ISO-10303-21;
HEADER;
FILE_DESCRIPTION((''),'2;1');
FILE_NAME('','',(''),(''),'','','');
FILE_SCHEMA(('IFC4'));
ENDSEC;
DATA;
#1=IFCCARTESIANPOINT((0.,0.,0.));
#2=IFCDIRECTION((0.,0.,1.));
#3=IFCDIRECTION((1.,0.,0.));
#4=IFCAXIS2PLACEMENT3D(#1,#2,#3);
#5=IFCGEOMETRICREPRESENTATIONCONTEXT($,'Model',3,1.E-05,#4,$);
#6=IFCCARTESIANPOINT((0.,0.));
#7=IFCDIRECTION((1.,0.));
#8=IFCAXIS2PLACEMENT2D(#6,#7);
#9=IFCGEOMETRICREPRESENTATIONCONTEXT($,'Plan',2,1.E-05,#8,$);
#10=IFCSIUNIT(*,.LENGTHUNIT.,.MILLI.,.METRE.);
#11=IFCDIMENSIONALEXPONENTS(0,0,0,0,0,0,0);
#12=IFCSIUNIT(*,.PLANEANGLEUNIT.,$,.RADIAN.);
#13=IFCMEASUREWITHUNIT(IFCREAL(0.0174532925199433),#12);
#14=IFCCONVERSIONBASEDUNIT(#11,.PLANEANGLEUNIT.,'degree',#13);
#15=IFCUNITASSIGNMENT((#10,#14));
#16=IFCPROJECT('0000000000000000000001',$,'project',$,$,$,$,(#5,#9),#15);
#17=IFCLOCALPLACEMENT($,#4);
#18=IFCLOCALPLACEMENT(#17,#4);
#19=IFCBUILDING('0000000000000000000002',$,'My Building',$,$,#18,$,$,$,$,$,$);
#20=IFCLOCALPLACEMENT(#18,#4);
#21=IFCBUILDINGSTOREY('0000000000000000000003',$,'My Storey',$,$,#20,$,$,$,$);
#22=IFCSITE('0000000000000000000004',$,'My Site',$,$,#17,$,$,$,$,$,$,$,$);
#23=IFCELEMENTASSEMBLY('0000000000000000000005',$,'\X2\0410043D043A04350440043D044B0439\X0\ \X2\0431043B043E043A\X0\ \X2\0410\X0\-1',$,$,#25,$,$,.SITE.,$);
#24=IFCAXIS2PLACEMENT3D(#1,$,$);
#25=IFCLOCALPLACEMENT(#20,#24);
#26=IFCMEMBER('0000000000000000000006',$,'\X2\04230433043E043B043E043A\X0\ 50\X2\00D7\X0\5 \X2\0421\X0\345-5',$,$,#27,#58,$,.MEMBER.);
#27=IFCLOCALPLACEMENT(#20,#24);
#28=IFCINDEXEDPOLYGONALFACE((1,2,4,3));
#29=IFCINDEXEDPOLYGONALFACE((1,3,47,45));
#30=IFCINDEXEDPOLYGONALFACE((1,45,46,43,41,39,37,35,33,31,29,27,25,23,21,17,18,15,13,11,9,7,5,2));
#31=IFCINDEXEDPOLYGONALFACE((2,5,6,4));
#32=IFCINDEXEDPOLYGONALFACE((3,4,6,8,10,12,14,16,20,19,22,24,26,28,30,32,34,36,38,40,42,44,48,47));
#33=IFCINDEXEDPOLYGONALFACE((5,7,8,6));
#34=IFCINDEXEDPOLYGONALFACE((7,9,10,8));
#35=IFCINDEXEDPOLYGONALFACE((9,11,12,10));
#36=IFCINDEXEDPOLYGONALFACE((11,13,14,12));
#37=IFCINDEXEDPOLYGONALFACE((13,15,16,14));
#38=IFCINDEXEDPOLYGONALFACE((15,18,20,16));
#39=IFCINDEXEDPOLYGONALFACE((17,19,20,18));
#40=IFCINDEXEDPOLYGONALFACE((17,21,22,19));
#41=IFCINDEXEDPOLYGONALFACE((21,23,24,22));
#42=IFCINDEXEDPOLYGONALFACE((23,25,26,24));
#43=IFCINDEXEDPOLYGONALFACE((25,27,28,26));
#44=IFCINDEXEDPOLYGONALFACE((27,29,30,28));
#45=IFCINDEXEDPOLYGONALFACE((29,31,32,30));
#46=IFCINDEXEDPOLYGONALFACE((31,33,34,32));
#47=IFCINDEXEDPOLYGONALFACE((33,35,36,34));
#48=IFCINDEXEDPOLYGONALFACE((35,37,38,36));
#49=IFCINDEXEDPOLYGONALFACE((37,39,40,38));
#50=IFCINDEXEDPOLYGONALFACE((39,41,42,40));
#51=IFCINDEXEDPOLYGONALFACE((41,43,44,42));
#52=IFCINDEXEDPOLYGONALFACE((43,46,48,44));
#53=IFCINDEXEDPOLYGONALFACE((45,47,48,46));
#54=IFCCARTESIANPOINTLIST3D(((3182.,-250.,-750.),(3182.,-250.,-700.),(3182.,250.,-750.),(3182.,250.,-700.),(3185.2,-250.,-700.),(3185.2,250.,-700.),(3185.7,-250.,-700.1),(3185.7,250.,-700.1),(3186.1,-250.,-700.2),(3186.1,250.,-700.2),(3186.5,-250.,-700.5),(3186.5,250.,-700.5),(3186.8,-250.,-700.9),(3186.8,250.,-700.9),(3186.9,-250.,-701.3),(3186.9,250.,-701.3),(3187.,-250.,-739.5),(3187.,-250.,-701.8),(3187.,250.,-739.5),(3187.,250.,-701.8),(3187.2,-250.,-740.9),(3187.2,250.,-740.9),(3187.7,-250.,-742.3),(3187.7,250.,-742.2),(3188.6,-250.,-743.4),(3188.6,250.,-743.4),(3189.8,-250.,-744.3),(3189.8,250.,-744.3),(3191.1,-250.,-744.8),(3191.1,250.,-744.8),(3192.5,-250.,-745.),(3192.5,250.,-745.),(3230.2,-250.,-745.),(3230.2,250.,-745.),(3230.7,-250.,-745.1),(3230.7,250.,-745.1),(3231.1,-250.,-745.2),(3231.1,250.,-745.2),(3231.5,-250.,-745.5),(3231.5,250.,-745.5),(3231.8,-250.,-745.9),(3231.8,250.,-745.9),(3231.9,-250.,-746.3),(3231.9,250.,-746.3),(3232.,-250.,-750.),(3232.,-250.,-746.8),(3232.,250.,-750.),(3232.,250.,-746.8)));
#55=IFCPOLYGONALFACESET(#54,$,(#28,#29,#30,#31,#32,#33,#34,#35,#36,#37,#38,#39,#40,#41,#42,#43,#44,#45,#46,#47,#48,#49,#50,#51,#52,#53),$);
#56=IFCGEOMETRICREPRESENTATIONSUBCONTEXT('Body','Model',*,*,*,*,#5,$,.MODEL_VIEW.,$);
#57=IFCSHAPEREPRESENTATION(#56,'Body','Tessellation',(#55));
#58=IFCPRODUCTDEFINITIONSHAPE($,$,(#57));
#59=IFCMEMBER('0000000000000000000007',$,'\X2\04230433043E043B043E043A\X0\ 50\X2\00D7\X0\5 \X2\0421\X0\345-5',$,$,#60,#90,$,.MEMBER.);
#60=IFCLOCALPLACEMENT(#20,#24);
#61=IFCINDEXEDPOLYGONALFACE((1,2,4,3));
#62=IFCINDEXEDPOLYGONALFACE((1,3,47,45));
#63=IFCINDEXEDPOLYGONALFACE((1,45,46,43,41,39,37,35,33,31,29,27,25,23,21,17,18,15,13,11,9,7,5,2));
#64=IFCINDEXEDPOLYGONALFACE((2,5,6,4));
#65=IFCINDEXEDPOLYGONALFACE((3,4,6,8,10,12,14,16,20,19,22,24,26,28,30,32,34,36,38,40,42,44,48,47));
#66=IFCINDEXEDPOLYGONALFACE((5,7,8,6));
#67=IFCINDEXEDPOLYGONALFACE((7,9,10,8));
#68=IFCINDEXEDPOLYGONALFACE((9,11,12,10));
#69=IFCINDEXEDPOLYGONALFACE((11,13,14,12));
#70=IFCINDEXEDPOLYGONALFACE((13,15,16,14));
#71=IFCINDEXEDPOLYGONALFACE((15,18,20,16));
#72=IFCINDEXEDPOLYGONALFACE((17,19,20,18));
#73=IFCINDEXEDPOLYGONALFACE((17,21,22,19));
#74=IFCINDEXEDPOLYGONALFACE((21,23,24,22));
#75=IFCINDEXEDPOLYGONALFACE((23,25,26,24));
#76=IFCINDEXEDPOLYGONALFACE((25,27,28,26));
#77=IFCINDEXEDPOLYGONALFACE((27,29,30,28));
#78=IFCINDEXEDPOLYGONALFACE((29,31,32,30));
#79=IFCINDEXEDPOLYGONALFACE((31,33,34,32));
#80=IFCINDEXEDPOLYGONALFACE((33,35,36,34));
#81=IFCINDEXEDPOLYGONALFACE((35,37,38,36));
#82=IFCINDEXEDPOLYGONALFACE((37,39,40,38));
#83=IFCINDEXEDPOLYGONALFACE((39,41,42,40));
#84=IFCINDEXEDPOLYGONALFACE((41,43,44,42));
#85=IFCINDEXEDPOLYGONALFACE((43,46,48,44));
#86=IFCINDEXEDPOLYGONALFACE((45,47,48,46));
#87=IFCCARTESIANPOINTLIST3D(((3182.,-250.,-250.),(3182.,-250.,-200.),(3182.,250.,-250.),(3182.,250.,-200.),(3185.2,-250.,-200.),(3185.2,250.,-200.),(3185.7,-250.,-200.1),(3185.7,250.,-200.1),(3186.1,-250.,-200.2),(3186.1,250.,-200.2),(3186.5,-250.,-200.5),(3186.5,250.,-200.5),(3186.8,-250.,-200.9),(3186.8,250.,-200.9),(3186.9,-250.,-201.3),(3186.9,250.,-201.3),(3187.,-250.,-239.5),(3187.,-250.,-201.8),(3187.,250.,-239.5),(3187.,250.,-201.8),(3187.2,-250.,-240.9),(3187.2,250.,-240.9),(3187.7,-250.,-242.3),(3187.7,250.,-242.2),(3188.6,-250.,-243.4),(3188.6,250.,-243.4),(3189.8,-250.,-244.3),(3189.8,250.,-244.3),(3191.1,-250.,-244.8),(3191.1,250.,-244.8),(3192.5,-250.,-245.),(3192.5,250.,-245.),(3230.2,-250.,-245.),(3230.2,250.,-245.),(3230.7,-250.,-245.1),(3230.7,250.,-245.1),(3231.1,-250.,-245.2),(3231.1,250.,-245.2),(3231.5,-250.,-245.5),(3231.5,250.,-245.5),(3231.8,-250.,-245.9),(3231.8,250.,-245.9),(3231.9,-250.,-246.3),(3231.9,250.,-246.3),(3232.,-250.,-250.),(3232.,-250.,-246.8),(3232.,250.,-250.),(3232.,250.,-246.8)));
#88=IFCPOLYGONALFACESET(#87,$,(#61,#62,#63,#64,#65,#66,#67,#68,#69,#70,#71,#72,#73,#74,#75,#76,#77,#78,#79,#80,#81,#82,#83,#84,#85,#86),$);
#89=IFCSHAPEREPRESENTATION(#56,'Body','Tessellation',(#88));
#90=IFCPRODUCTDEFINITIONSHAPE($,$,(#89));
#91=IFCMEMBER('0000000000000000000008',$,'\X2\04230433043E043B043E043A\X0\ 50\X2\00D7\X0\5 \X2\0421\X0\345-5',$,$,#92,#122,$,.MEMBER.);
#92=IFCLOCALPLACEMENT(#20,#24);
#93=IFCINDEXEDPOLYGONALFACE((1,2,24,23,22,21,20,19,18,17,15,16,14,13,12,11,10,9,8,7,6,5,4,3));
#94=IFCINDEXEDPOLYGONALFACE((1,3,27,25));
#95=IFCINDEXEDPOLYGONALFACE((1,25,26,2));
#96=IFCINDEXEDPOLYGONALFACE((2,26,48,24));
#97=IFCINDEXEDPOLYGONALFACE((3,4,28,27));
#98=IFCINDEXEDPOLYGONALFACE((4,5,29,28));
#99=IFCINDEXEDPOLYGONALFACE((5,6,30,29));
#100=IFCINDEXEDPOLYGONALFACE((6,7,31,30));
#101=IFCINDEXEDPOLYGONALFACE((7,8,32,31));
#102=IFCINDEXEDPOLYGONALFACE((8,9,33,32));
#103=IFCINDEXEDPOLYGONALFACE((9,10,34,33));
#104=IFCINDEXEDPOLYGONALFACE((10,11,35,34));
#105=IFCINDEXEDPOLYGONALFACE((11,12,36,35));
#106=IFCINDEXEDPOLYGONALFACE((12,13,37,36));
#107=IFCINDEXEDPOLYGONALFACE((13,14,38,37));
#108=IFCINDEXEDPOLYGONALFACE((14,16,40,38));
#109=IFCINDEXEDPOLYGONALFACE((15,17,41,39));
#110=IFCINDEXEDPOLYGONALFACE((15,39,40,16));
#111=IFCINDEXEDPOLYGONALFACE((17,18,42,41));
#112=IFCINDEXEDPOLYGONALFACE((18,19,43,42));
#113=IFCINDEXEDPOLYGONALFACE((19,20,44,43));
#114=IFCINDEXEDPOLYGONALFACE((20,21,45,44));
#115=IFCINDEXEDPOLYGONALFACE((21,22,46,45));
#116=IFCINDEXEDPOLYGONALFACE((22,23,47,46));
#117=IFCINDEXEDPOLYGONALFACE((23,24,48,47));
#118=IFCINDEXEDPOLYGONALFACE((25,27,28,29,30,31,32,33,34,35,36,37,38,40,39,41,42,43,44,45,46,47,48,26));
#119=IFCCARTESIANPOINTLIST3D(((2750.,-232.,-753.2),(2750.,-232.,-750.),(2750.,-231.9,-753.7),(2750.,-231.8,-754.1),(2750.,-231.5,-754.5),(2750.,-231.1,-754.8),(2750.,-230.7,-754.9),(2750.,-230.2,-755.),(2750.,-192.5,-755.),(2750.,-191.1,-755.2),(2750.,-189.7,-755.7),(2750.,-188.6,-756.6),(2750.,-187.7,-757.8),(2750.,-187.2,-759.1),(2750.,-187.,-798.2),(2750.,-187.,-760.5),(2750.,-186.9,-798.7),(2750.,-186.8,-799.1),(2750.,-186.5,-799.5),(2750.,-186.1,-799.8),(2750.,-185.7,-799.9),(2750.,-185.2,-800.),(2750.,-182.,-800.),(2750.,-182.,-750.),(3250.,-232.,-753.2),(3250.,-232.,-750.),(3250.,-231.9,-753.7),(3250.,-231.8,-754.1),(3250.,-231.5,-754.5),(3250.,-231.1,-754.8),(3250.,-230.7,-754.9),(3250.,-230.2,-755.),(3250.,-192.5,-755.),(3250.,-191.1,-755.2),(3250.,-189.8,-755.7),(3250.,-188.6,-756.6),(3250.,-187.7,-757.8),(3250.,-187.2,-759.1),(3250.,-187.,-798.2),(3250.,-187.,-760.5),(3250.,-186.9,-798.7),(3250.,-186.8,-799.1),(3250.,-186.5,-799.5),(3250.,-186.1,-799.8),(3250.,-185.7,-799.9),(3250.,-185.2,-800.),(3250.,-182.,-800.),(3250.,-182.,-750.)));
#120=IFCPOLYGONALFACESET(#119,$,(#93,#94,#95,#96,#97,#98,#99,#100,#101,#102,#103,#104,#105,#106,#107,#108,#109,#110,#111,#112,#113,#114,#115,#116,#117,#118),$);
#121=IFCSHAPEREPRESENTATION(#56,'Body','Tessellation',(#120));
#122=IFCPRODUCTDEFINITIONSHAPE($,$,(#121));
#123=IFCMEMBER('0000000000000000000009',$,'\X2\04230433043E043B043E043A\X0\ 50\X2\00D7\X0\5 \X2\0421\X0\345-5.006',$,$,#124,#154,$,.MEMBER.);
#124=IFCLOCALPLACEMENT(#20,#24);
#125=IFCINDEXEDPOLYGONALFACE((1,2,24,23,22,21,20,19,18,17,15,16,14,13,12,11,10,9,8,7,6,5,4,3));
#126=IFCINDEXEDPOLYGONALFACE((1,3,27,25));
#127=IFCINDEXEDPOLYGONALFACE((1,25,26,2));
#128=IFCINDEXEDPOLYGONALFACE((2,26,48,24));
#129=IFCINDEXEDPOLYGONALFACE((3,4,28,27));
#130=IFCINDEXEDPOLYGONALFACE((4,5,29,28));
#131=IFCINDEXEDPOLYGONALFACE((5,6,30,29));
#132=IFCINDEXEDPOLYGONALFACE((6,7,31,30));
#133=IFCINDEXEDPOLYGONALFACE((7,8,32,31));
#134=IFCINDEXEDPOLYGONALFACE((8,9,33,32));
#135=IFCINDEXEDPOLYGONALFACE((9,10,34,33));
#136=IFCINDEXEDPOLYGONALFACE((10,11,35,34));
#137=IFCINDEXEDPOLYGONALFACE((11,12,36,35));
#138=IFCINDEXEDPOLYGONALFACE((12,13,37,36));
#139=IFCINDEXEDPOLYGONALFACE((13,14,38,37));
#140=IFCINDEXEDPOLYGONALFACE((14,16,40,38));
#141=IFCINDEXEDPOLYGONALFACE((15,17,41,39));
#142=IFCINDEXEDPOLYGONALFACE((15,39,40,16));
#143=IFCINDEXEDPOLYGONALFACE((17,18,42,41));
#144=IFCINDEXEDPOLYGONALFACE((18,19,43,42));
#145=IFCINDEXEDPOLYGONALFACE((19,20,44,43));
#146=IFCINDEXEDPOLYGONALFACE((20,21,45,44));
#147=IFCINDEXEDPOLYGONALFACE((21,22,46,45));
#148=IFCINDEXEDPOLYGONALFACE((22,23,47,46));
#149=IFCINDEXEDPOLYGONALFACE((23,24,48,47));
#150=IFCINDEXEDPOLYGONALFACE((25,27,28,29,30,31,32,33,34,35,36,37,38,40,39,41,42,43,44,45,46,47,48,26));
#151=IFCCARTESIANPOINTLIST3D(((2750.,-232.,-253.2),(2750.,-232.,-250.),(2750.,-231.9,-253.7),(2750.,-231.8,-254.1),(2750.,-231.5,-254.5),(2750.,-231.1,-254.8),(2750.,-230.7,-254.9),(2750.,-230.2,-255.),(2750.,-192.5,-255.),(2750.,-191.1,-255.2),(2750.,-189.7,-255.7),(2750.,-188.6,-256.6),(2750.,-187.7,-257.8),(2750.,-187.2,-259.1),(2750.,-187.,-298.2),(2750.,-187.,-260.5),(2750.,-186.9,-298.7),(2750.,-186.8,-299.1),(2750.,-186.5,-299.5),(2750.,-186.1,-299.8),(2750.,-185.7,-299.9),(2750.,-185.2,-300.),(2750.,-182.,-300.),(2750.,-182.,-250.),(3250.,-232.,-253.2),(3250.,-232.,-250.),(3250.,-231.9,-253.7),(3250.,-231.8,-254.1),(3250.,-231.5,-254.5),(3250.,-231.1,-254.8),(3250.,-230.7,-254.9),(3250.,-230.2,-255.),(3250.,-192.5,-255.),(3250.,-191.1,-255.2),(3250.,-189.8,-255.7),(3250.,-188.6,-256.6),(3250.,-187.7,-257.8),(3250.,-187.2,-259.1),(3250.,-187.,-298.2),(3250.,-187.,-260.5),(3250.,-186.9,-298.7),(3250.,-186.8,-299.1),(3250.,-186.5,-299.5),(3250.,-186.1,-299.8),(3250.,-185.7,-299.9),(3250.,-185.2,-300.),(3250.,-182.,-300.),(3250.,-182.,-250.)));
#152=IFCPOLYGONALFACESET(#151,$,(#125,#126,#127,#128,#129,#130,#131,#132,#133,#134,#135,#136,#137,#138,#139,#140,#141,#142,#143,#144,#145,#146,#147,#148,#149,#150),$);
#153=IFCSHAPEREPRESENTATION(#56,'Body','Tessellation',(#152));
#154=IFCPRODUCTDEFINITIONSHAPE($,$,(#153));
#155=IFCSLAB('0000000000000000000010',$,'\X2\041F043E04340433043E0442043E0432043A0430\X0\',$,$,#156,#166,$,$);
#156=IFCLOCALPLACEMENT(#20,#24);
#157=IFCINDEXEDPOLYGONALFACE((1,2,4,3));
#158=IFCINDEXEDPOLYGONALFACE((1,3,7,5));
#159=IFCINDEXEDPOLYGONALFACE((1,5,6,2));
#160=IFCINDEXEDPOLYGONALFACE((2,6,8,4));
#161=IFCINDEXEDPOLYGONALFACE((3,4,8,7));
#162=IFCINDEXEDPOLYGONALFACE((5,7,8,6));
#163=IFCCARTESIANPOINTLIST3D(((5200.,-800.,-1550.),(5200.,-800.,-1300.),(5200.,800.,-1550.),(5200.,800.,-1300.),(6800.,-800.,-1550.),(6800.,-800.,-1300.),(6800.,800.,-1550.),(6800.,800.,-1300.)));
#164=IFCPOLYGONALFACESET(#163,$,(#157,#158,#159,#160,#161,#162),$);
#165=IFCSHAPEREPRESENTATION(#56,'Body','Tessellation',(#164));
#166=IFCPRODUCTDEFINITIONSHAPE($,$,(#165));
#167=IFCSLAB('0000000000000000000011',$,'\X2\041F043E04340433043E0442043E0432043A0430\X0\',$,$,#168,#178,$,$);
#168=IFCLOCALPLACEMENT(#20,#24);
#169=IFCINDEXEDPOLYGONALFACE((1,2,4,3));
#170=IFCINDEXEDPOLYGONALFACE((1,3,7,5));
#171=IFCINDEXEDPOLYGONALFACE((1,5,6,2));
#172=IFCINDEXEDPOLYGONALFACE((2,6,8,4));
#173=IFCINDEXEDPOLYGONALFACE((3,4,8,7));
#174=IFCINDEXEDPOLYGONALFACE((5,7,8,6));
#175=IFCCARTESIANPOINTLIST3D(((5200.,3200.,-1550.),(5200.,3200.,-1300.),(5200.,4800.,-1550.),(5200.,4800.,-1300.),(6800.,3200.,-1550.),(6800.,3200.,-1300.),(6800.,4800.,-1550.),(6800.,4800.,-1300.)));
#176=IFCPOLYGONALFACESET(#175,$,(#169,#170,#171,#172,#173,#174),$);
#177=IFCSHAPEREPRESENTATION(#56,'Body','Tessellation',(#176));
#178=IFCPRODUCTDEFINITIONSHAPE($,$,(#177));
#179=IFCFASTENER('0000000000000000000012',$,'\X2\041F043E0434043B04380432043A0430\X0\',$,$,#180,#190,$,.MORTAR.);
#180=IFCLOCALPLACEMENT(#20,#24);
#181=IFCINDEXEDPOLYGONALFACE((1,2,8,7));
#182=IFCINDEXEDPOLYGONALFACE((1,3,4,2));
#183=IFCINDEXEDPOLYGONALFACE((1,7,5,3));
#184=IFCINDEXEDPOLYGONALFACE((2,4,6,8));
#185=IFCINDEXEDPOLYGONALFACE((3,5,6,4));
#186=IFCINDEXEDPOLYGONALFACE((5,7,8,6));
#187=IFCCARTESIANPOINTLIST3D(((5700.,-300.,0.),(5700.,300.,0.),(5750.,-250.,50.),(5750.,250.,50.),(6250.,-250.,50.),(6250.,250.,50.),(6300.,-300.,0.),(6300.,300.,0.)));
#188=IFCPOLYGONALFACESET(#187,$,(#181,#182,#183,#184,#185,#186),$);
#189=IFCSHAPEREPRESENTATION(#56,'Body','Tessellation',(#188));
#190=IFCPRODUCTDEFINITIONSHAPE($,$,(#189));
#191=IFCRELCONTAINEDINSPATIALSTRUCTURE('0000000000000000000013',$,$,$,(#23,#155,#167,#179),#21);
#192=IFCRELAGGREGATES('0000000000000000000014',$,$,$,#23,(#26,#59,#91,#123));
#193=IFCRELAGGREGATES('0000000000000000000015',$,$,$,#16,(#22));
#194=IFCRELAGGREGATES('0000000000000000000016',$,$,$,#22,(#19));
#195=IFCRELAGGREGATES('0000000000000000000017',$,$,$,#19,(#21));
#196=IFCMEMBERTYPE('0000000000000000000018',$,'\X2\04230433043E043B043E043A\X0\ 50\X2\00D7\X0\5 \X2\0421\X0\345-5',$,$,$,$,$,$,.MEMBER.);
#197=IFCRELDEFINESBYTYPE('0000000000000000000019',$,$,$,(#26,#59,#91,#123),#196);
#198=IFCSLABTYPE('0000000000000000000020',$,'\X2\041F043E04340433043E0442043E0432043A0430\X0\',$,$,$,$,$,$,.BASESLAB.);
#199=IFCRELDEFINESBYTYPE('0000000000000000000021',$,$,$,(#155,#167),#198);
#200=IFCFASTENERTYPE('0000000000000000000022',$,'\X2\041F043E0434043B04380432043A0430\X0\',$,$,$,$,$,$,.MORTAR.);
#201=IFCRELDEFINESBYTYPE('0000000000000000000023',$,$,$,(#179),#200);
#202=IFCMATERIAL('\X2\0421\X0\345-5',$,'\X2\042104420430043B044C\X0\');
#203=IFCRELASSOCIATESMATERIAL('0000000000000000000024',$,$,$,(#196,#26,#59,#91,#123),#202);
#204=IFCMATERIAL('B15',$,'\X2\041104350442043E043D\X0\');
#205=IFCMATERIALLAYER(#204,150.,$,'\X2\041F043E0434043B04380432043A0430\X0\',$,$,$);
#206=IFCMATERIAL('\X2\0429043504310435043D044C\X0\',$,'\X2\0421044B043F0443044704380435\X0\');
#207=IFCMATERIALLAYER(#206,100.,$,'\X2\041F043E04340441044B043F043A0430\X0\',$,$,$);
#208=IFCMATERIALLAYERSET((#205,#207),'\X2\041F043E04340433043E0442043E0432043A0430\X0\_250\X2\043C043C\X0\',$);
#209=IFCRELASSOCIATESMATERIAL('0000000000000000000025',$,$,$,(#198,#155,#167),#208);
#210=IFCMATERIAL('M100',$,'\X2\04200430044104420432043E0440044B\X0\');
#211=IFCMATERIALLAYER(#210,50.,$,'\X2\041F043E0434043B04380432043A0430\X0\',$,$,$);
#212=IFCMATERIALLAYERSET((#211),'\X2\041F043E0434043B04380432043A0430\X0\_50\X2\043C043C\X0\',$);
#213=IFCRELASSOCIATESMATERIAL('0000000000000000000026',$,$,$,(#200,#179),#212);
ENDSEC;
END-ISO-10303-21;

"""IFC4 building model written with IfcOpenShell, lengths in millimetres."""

from ifc_helpers import new_model, entity, si_unit, converted_unit, frame, origin_with_axes, origin_2d_with_axis, place, context, subcontext, project, spatial, line, indexed_curve, l_section, outline, extrude, clip, halfspace, material, layer, layer_set, layer_usage, material_profile, profile_set, profile_usage, type_object, element, aggregate, save


model = new_model("IFC4")

# Units and contexts
model_context = context("Model", 3, precision=1e-05, world=origin_with_axes())
plan_context = context("Plan", 2, precision=1e-05, world=origin_2d_with_axis())
body_context = subcontext(model_context, "Body", "Model", "MODEL_VIEW")
ifc_project = project(units=[si_unit("LENGTHUNIT", "METRE", prefix="MILLI"), converted_unit("PLANEANGLEUNIT", "degree", entity("IfcReal", 0.0174532925199433), si_unit("PLANEANGLEUNIT", "RADIAN"), dimensions=[0, 0, 0, 0, 0, 0, 0])], contexts=[model_context, plan_context])

# Site, building, storey
site_placement = place(None, origin_with_axes())
site = spatial("IfcSite", under=ifc_project, at=site_placement, Name="My Site")
building_placement = place(site_placement, origin_with_axes())
building = spatial("IfcBuilding", under=site, at=building_placement, Name="My Building")
storey_placement = place(building_placement, origin_with_axes())
storey = spatial("IfcBuildingStorey", under=building, at=storey_placement, Name="My Storey")

# Element assembly, members
assembly_1_placement = place(storey_placement, frame((3000.0, 0.0, 0.0), z_axis=(0.0, 0.0, 1.0), x_axis=(1.0, 0.0, 0.0)))
assembly_1 = element("IfcElementAssembly", 1, at=assembly_1_placement, inside=storey, Name="Анкерный блок А-1", AssemblyPlace="SITE")
ifc_material_1 = material(Name="С345-5", Category="Сталь")
ifc_material_profile = material_profile(ifc_material_1, l_section(Depth=50.0, Width=50.0, Thickness=5.0, FilletRadius=5.5, EdgeRadius=1.8))
ifc_profile_set = profile_set([ifc_material_profile])
ifc_profile_usage_1 = profile_usage(ifc_profile_set, cardinal=3)
member_type = type_object("IfcMemberType", Name="Уголок 50×5 С345-5", PredefinedType="MEMBER", material=ifc_profile_set)
member_1_placement = place(assembly_1_placement, frame((182.0, 250.0, -750.0), z_axis=(0.0, -1.0, 0.0), x_axis=(1.0, 0.0, 0.0)))
member_1 = element("IfcMember", 2, at=member_1_placement, type_object=member_type, material=ifc_profile_usage_1, Name="Уголок 50×5 С345-5", PredefinedType="MEMBER", context=body_context, shape_type="SweptSolid", body=[
    extrude(l_section(Depth=50.0, Width=50.0, Thickness=5.0, FilletRadius=5.5, EdgeRadius=1.8), frame((25.0, 25.0, 0.0), z_axis=(0.0, 0.0, 1.0), x_axis=(1.0, 0.0, 0.0)), (0.0, 0.0, 1.0), 500.0),
])
ifc_profile_usage_2 = profile_usage(ifc_profile_set, cardinal=3)
member_2_placement = place(assembly_1_placement, frame((182.0, 250.0, -250.0), z_axis=(0.0, -1.0, 0.0), x_axis=(1.0, 0.0, 0.0)))
member_2 = element("IfcMember", 3, at=member_2_placement, type_object=member_type, material=ifc_profile_usage_2, Name="Уголок 50×5 С345-5", PredefinedType="MEMBER", context=body_context, shape_type="SweptSolid", body=[
    extrude(l_section(Depth=50.0, Width=50.0, Thickness=5.0, FilletRadius=5.5, EdgeRadius=1.8), frame((25.0, 25.0, 0.0), z_axis=(0.0, 0.0, 1.0), x_axis=(1.0, 0.0, 0.0)), (0.0, 0.0, 1.0), 500.0),
])
ifc_profile_usage_3 = profile_usage(ifc_profile_set, cardinal=3)
member_3_placement = place(assembly_1_placement, frame((250.0, -182.0, -750.0), z_axis=(-1.0, 0.0, 0.0), x_axis=(0.0, 0.0, -1.0)))
member_3 = element("IfcMember", 4, at=member_3_placement, type_object=member_type, material=ifc_profile_usage_3, Name="Уголок 50×5 С345-5", PredefinedType="MEMBER", context=body_context, shape_type="SweptSolid", body=[
    extrude(l_section(Depth=50.0, Width=50.0, Thickness=5.0, FilletRadius=5.5, EdgeRadius=1.8), frame((25.0, 25.0, 0.0), z_axis=(0.0, 0.0, 1.0), x_axis=(1.0, 0.0, 0.0)), (0.0, 0.0, 1.0), 500.0),
])
ifc_profile_usage_4 = profile_usage(ifc_profile_set, cardinal=3)
member_4_placement = place(assembly_1_placement, frame((250.0, -182.0, -250.0), z_axis=(-1.0, 0.0, 0.0), x_axis=(0.0, 0.0, -1.0)))
member_4 = element("IfcMember", 5, at=member_4_placement, type_object=member_type, material=ifc_profile_usage_4, Name="Уголок 50×5 С345-5.006", PredefinedType="MEMBER", context=body_context, shape_type="SweptSolid", body=[
    extrude(l_section(Depth=50.0, Width=50.0, Thickness=5.0, FilletRadius=5.5, EdgeRadius=1.8), frame((25.0, 25.0, 0.0), z_axis=(0.0, 0.0, 1.0), x_axis=(1.0, 0.0, 0.0)), (0.0, 0.0, 1.0), 500.0),
])

# Slabs
ifc_material_2 = material(Name="B15", Category="Бетон")
ifc_layer_1 = layer(ifc_material_2, 150.0, Name="Подливка")
ifc_material_3 = material(Name="Щебень", Category="Сыпучие")
ifc_layer_2 = layer(ifc_material_3, 100.0, Name="Подсыпка")
ifc_layer_set_1 = layer_set([ifc_layer_1, ifc_layer_2], Name="Подготовка_250мм")
ifc_layer_usage_1 = layer_usage(ifc_layer_set_1, "AXIS3", "NEGATIVE", 0.0)
slab_type = type_object("IfcSlabType", Name="Подготовка", PredefinedType="BASESLAB", material=ifc_layer_set_1)
for number, where, z_axis, x_axis, name in (
    (6, (6000.0, 0.0, -1550.0), (0.0, 0.0, 1.0), (1.0, 0.0, 0.0), "Подготовка"),
    (7, (6000.0, 4000.0, -1550.0), (0.0, 0.0, 1.0), (1.0, 0.0, 0.0), "Подготовка"),
):
    element("IfcSlab", number, at=place(storey_placement, frame(where, z_axis=z_axis, x_axis=x_axis)), inside=storey, type_object=slab_type, material=ifc_layer_usage_1, Name=name, context=body_context, shape_type="SweptSolid", body=[
        extrude(outline(indexed_curve([(-800.0, -800.0), (800.0, -800.0), (800.0, 800.0), (-800.0, 800.0)], segments=[line(3, 2), line(2, 1), line(1, 4), line(4, 3)], self_intersect=False)), None, (0.0, 0.0, 1.0), 250.0),
    ])

# Fastener
ifc_material_4 = material(Name="M100", Category="Растворы")
ifc_layer_3 = layer(ifc_material_4, 50.0, Name="Подливка")
ifc_layer_set_2 = layer_set([ifc_layer_3], Name="Подливка_50мм")
ifc_layer_usage_2 = layer_usage(ifc_layer_set_2, "AXIS3", "POSITIVE", 0.0)
fastener_type = type_object("IfcFastenerType", Name="Подливка", PredefinedType="MORTAR", material=ifc_layer_set_2)
fastener_1_placement = place(storey_placement, frame((6000.0, 0.0, 0.0), z_axis=(0.0, 0.0, 1.0), x_axis=(1.0, 0.0, 0.0)))
element("IfcFastener", 8, at=fastener_1_placement, inside=storey, type_object=fastener_type, material=ifc_layer_usage_2, Name="Подливка", PredefinedType="MORTAR", context=body_context, shape_type="Clipping", body=[
    clip(clip(clip(clip(extrude(outline(indexed_curve([(-300.0, -300.0), (300.0, -300.0), (300.0, 300.0), (-300.0, 300.0)], segments=[line(3, 2), line(2, 1), line(1, 4), line(4, 3)], self_intersect=False)), None, (0.0, 0.0, 1.0), 50.0), halfspace(frame((-53.6, 200.0, 353.6), z_axis=(0.707107, 0.0, 0.707107), x_axis=(0.707107, 0.0, -0.707107)), False)), halfspace(frame((-200.0, -53.6, 353.6), z_axis=(0.0, 0.707107, 0.707107), x_axis=(0.0, 0.707107, -0.707107)), False)), halfspace(frame((200.0, 53.6, 353.6), z_axis=(0.0, -0.707107, 0.707107), x_axis=(0.0, -0.707107, -0.707107)), False)), halfspace(frame((53.6, 200.0, 353.6), z_axis=(-0.707107, 0.0, 0.707107), x_axis=(-0.707107, 0.0, -0.707107)), False)),
])

aggregate(assembly_1, [member_1, member_2, member_3, member_4])

save(model, "model.ifc")
